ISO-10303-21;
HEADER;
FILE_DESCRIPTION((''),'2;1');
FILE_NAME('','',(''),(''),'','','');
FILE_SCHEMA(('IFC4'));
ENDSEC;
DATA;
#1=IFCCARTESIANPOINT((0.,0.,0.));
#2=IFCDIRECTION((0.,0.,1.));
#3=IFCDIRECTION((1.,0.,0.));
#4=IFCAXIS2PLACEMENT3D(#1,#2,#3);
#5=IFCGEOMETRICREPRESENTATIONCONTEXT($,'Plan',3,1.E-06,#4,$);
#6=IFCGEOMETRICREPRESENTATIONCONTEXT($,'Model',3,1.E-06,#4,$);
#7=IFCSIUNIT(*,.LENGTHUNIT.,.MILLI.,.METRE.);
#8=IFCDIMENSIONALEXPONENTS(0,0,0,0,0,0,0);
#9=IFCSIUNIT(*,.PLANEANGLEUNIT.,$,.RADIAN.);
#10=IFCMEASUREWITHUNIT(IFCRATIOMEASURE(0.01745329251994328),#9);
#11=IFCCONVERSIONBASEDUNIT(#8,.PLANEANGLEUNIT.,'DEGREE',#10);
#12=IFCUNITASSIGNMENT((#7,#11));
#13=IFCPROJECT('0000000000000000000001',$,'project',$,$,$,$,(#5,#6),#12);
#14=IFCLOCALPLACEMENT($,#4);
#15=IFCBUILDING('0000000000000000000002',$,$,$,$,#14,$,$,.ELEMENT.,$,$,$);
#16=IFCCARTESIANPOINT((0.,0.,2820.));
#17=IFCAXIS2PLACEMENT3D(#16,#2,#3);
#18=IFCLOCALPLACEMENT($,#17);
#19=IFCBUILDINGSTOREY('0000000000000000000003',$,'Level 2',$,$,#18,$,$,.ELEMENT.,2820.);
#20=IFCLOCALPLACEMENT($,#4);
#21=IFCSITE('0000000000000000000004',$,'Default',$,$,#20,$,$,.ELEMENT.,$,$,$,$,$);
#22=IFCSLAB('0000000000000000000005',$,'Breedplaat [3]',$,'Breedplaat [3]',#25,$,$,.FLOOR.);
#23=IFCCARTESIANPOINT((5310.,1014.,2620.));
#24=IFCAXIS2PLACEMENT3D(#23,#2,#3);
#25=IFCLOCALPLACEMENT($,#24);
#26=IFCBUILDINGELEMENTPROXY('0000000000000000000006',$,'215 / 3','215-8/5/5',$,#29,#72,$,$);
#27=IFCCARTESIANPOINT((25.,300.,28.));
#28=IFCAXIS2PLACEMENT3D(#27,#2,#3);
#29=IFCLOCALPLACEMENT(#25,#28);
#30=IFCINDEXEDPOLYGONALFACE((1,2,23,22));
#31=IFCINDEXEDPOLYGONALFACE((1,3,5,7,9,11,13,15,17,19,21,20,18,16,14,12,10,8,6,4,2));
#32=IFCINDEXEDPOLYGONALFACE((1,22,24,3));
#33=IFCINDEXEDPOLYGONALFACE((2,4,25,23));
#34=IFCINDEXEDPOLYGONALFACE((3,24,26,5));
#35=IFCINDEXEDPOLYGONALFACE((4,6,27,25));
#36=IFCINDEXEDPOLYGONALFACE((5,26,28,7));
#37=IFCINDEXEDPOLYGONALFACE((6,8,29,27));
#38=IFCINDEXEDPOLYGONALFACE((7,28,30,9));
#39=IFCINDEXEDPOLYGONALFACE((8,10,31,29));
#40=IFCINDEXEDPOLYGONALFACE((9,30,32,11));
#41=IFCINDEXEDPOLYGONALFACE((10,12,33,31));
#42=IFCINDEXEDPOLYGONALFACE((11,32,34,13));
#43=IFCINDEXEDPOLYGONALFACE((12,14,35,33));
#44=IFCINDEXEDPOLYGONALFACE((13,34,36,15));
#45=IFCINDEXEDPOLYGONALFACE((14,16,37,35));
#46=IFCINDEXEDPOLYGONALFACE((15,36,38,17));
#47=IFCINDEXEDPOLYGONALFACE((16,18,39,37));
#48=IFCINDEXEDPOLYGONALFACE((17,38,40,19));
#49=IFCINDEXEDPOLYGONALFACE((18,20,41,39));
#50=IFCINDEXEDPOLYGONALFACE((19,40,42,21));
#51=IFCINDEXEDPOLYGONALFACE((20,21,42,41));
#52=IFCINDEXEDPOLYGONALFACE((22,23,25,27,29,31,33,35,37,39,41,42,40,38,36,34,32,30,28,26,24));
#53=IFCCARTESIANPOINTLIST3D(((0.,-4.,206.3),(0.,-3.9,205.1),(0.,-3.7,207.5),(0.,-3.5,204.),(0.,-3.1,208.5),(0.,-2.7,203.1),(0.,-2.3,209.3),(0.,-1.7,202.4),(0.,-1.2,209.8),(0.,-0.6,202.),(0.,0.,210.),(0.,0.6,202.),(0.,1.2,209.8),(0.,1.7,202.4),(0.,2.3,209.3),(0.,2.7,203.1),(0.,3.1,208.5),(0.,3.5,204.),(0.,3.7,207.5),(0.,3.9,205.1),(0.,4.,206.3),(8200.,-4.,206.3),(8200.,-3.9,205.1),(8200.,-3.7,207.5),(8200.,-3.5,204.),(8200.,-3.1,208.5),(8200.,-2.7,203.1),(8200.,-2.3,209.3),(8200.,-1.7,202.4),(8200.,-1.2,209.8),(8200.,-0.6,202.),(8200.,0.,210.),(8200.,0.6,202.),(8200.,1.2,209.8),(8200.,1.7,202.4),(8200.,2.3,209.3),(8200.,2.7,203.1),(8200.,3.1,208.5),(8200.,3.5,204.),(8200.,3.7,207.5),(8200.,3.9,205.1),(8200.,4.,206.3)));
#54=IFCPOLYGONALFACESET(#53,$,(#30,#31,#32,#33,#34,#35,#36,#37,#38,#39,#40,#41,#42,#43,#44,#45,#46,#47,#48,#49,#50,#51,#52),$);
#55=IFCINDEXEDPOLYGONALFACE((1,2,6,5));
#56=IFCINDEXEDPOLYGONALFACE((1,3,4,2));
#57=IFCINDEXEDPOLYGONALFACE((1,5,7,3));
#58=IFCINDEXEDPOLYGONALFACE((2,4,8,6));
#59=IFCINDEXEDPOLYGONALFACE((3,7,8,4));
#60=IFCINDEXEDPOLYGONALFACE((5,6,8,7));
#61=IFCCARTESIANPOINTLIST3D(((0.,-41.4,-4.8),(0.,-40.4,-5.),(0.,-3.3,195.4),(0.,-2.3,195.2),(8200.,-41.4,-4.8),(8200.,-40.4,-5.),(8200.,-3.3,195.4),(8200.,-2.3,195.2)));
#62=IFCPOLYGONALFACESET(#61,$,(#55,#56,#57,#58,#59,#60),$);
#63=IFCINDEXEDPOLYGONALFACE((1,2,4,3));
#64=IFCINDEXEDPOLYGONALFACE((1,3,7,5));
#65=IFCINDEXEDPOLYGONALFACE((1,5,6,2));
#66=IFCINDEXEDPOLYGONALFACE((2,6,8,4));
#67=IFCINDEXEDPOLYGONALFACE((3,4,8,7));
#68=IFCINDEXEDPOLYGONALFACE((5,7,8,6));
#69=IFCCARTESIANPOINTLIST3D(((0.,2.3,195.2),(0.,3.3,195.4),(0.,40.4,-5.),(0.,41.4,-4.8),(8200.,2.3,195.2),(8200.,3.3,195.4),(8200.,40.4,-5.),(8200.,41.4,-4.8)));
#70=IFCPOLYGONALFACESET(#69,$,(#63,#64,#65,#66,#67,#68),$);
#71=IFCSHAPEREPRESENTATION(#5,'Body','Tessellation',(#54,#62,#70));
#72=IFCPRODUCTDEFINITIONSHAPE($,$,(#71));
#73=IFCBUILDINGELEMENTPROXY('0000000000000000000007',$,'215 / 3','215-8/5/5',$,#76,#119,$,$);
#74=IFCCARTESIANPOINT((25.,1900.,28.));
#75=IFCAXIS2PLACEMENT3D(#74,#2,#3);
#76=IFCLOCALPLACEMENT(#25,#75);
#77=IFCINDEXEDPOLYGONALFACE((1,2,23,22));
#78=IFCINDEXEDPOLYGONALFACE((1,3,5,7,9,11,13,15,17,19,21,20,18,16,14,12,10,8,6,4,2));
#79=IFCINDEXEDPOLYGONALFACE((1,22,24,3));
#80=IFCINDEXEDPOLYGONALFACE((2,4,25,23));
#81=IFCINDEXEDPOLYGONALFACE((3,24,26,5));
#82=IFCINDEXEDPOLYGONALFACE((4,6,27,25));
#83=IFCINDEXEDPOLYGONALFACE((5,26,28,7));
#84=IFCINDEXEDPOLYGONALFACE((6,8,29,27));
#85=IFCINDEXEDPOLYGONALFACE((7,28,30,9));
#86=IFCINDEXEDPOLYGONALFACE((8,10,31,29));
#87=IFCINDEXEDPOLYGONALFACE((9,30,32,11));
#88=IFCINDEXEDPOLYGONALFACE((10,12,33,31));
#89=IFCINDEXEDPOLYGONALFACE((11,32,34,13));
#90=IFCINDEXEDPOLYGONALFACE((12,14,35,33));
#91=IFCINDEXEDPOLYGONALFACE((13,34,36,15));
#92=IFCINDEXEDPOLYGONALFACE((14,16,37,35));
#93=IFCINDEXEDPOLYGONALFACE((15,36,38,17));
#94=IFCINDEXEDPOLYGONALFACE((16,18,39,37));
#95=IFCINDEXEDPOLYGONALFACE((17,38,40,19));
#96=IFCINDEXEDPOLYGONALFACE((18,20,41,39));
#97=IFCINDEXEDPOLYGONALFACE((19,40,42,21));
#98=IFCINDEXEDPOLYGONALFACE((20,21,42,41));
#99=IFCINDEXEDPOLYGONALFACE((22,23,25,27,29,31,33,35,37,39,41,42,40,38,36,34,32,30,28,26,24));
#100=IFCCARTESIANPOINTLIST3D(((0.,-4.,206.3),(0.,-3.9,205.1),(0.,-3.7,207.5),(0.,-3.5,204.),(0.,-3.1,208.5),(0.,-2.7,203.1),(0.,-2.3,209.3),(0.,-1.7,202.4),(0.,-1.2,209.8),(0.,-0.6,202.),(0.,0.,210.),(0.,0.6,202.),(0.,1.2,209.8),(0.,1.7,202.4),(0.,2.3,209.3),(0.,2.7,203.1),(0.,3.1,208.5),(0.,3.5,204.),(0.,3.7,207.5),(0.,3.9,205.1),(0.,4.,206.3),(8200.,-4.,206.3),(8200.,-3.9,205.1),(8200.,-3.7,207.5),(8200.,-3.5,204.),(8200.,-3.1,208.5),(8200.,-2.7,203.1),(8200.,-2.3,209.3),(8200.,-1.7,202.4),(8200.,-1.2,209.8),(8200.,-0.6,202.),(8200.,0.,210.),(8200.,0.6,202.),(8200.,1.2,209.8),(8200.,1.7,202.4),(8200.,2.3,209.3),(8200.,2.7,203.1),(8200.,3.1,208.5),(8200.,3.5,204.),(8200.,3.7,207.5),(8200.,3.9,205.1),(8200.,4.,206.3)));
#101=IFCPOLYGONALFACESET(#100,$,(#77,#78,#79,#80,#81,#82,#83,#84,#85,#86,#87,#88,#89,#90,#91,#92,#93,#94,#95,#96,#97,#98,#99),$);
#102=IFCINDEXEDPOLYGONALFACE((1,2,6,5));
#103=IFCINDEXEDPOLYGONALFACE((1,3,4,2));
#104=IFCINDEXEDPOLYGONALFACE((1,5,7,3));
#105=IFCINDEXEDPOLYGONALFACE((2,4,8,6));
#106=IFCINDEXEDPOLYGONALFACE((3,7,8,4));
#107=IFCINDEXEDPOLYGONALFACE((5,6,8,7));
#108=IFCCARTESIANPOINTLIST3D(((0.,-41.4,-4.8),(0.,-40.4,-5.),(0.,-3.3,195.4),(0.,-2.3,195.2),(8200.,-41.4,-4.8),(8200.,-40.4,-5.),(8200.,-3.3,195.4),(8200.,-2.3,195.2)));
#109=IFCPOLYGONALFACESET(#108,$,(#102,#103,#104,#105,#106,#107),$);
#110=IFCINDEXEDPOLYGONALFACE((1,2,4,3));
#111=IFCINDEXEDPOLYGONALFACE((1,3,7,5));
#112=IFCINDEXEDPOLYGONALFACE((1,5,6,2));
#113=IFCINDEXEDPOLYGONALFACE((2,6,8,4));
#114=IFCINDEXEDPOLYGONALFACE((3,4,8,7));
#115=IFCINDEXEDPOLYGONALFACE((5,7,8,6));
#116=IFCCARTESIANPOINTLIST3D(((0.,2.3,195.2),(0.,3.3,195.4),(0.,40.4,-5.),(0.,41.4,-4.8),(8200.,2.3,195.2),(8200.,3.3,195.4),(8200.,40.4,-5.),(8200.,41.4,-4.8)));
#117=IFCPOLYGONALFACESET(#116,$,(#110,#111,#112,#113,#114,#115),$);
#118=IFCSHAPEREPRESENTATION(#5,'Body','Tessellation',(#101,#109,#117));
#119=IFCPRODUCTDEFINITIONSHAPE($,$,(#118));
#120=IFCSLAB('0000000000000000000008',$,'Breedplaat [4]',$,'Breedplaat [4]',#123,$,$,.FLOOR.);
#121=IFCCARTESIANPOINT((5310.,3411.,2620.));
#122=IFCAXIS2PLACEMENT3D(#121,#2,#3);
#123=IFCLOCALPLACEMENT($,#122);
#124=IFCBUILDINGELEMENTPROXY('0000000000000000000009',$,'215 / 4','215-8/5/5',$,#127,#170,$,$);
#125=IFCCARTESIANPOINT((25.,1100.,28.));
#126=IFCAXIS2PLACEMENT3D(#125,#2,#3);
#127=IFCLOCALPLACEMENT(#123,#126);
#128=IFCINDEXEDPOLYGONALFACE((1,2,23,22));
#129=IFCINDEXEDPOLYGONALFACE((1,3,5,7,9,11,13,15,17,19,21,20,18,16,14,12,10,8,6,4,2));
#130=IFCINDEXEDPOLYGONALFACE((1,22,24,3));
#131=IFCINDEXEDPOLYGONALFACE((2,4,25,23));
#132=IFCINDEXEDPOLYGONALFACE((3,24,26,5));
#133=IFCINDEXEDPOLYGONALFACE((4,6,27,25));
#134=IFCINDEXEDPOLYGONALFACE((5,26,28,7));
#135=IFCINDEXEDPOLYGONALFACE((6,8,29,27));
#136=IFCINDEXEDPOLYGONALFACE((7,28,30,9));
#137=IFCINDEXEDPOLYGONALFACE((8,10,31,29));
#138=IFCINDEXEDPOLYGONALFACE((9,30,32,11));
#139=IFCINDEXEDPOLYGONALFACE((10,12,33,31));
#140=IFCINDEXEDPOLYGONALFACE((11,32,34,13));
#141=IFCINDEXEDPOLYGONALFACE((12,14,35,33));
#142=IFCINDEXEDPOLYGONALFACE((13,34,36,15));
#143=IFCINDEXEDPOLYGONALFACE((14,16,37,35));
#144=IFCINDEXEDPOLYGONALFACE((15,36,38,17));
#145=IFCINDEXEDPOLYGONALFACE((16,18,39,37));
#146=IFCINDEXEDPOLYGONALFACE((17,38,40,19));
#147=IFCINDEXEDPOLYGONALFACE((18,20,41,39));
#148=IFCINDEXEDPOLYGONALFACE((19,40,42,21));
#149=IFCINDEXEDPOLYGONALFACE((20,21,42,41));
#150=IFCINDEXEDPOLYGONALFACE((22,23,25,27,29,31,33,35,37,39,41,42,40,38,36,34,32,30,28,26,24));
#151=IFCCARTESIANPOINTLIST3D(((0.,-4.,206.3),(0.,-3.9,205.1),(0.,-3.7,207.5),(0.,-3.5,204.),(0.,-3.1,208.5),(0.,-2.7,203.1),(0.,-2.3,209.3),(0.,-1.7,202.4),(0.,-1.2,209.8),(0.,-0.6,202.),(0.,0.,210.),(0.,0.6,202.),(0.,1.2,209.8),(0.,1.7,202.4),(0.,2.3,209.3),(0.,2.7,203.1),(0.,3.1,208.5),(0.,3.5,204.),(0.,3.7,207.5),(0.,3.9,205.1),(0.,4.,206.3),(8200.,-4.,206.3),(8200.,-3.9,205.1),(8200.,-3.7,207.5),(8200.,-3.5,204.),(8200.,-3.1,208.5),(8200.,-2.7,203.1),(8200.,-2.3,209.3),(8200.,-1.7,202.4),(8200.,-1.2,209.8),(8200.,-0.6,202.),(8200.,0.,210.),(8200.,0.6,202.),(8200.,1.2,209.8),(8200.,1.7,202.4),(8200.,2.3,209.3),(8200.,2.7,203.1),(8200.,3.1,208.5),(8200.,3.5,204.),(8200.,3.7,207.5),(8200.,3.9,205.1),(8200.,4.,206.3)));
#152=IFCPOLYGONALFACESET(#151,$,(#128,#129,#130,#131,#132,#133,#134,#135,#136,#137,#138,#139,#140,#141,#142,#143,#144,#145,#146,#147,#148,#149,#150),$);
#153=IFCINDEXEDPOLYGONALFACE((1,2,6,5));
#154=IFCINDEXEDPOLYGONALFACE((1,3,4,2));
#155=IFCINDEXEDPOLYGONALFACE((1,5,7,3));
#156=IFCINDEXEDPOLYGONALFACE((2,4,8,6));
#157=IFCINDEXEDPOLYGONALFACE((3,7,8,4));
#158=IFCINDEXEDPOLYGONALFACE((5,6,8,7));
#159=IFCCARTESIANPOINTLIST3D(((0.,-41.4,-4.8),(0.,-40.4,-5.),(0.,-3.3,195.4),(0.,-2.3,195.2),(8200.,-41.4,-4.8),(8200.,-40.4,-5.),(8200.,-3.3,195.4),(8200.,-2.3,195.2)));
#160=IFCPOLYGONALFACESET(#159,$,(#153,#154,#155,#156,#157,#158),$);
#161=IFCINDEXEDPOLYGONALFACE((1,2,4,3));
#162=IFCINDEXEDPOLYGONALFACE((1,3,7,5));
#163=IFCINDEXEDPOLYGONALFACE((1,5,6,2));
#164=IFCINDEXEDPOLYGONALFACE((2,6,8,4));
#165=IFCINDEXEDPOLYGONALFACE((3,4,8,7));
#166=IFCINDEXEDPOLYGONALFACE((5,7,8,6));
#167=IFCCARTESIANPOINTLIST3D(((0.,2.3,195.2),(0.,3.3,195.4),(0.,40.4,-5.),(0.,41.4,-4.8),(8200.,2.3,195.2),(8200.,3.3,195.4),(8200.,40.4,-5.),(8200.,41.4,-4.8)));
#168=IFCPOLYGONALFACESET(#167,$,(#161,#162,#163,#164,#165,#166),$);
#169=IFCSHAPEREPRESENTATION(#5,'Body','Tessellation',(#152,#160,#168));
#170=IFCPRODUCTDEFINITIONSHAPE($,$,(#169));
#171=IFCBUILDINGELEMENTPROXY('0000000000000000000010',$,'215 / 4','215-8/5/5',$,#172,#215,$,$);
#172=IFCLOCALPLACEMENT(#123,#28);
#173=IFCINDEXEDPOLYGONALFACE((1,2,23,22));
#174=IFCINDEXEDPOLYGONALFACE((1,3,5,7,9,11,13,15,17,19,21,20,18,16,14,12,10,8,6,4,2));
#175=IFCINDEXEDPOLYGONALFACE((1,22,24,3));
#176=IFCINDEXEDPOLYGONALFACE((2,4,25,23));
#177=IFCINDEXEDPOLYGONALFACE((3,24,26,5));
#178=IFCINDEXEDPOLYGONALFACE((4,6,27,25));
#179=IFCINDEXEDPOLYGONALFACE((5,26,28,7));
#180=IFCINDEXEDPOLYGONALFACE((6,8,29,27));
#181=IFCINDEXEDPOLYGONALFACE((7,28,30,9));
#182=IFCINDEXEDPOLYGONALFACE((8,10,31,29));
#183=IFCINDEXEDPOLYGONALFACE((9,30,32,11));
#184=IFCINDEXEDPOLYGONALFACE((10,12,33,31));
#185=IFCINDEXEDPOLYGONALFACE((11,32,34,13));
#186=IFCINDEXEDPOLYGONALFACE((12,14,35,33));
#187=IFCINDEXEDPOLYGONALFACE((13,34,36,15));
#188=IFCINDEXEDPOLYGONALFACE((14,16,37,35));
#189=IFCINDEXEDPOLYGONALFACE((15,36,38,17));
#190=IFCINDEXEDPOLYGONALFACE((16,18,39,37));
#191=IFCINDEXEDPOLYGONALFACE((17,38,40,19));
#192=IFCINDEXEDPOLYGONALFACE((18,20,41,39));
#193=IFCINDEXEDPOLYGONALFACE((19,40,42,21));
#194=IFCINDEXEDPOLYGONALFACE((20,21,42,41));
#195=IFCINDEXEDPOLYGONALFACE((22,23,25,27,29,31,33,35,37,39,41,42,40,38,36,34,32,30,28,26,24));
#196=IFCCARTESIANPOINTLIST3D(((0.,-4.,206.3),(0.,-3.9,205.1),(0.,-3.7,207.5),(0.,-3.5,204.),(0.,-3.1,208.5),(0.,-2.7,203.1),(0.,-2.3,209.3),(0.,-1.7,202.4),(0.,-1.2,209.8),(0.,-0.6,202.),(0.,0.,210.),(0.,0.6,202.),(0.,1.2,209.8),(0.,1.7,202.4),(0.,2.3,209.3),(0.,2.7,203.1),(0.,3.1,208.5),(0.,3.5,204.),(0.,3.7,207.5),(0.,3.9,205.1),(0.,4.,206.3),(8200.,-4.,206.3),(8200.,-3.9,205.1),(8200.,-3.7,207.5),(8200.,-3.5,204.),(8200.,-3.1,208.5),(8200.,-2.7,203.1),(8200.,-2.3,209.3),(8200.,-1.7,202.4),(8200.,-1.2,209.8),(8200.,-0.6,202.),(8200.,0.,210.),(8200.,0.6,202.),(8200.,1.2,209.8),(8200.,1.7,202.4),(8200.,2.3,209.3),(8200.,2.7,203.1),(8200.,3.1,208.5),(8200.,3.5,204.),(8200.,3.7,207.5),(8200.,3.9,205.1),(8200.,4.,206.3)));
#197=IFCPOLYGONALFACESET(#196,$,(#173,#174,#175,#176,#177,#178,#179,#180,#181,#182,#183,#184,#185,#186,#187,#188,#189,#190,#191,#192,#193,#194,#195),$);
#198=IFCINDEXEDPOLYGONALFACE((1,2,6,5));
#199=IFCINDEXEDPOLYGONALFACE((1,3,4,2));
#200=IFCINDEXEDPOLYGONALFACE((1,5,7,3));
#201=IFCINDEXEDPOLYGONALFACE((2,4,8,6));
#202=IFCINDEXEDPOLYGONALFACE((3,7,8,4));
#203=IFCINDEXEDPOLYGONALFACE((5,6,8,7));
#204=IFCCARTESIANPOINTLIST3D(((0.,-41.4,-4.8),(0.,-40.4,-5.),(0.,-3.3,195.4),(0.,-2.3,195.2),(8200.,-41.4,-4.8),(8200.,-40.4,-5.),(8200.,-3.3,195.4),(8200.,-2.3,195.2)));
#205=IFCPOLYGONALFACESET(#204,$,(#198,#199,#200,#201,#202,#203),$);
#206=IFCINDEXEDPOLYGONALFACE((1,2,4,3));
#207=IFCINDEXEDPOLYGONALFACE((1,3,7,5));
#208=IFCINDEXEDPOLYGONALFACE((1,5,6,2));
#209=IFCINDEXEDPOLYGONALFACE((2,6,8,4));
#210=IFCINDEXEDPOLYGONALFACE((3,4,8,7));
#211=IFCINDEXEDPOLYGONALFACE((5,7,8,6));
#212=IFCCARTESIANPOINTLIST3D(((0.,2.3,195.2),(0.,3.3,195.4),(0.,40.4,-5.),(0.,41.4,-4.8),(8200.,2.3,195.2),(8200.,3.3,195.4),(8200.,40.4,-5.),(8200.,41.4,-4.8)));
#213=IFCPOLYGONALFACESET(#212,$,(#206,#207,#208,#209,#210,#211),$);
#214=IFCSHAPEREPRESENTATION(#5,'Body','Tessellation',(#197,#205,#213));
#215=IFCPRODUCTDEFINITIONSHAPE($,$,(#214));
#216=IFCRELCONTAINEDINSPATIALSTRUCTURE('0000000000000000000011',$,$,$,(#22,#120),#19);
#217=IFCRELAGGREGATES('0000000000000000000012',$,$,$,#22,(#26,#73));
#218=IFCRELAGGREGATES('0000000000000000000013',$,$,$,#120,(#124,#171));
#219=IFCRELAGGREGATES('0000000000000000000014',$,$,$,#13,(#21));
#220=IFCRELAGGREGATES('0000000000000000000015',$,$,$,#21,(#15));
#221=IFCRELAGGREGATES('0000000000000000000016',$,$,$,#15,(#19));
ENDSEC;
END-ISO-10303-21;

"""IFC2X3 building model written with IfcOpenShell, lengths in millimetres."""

from ifc_helpers import new_model, entity, si_unit, converted_unit, frame, origin_with_axes, origin_2d_with_axis, place, context, project, spatial, rectangle, circle, extrude, element, aggregate, save


model = new_model("IFC2X3")

# Units and contexts
plan_context = context("Plan", 3, precision=1e-06, world=origin_with_axes())
model_context = context("Model", 3, precision=1e-06, world=origin_with_axes())
ifc_project = project(units=[si_unit("LENGTHUNIT", "METRE", prefix="MILLI"), converted_unit("PLANEANGLEUNIT", "DEGREE", entity("IfcRatioMeasure", 0.01745329251994328), si_unit("PLANEANGLEUNIT", "RADIAN"), dimensions=[0, 0, 0, 0, 0, 0, 0])], contexts=[plan_context, model_context])

# Site, building, storey
site_placement = place(None, origin_with_axes())
site = spatial("IfcSite", under=ifc_project, at=site_placement, Name="Default", CompositionType="ELEMENT")
building_placement = place(None, origin_with_axes())
building = spatial("IfcBuilding", under=site, at=building_placement, CompositionType="ELEMENT")
storey_placement = place(None, frame((0.0, 0.0, 2820.0), z_axis=(0.0, 0.0, 1.0), x_axis=(1.0, 0.0, 0.0)))
storey = spatial("IfcBuildingStorey", under=building, at=storey_placement, Name="Level 2", CompositionType="ELEMENT", Elevation=2820.0)

# Slabs, building element proxies
slab_1_placement = place(None, frame((5310.0, 1014.0, 2620.0), z_axis=(0.0, 0.0, 1.0), x_axis=(1.0, 0.0, 0.0)))
slab_1 = element("IfcSlab", 1, at=slab_1_placement, inside=storey, Name="Breedplaat [3]", ObjectType="Breedplaat [3]", PredefinedType="FLOOR")
proxy_1_placement = place(slab_1_placement, frame((25.0, 300.0, 28.0), z_axis=(0.0, 0.0, 1.0), x_axis=(1.0, 0.0, 0.0)))
proxy_1 = element("IfcBuildingElementProxy", 2, at=proxy_1_placement, Name="215 / 3", Description="215-8/5/5", context=plan_context, shape_type="SweptSolid", body=[
    extrude(circle(Radius=4.0, at=origin_2d_with_axis()), frame((0.0, 0.0, 206.0), z_axis=(1.0, 0.0, 0.0), x_axis=(0.0, 0.0, 1.0)), (0.0, 0.0, 1.0), 8200.0),
    extrude(rectangle(XDim=203.8, YDim=1.0, at=origin_2d_with_axis()), frame((0.0, -21.9, 95.2), z_axis=(1.0, 0.0, 0.0), x_axis=(0.0, 0.187112, 0.982339)), (0.0, 0.0, 1.0), 8200.0),
    extrude(rectangle(XDim=203.8, YDim=1.0, at=origin_2d_with_axis()), frame((0.0, 21.9, 95.2), z_axis=(1.0, 0.0, 0.0), x_axis=(0.0, -0.187112, 0.982339)), (0.0, 0.0, 1.0), 8200.0),
])
proxy_2_placement = place(slab_1_placement, frame((25.0, 1900.0, 28.0), z_axis=(0.0, 0.0, 1.0), x_axis=(1.0, 0.0, 0.0)))
proxy_2 = element("IfcBuildingElementProxy", 3, at=proxy_2_placement, Name="215 / 3", Description="215-8/5/5", context=plan_context, shape_type="SweptSolid", body=[
    extrude(circle(Radius=4.0, at=origin_2d_with_axis()), frame((0.0, 0.0, 206.0), z_axis=(1.0, 0.0, 0.0), x_axis=(0.0, 0.0, 1.0)), (0.0, 0.0, 1.0), 8200.0),
    extrude(rectangle(XDim=203.8, YDim=1.0, at=origin_2d_with_axis()), frame((0.0, -21.9, 95.2), z_axis=(1.0, 0.0, 0.0), x_axis=(0.0, 0.187112, 0.982339)), (0.0, 0.0, 1.0), 8200.0),
    extrude(rectangle(XDim=203.8, YDim=1.0, at=origin_2d_with_axis()), frame((0.0, 21.9, 95.2), z_axis=(1.0, 0.0, 0.0), x_axis=(0.0, -0.187112, 0.982339)), (0.0, 0.0, 1.0), 8200.0),
])
aggregate(slab_1, [proxy_1, proxy_2])
slab_2_placement = place(None, frame((5310.0, 3411.0, 2620.0), z_axis=(0.0, 0.0, 1.0), x_axis=(1.0, 0.0, 0.0)))
slab_2 = element("IfcSlab", 4, at=slab_2_placement, inside=storey, Name="Breedplaat [4]", ObjectType="Breedplaat [4]", PredefinedType="FLOOR")
proxy_3_placement = place(slab_2_placement, frame((25.0, 1100.0, 28.0), z_axis=(0.0, 0.0, 1.0), x_axis=(1.0, 0.0, 0.0)))
proxy_3 = element("IfcBuildingElementProxy", 5, at=proxy_3_placement, Name="215 / 4", Description="215-8/5/5", context=plan_context, shape_type="SweptSolid", body=[
    extrude(circle(Radius=4.0, at=origin_2d_with_axis()), frame((0.0, 0.0, 206.0), z_axis=(1.0, 0.0, 0.0), x_axis=(0.0, 0.0, 1.0)), (0.0, 0.0, 1.0), 8200.0),
    extrude(rectangle(XDim=203.8, YDim=1.0, at=origin_2d_with_axis()), frame((0.0, -21.9, 95.2), z_axis=(1.0, 0.0, 0.0), x_axis=(0.0, 0.187112, 0.982339)), (0.0, 0.0, 1.0), 8200.0),
    extrude(rectangle(XDim=203.8, YDim=1.0, at=origin_2d_with_axis()), frame((0.0, 21.9, 95.2), z_axis=(1.0, 0.0, 0.0), x_axis=(0.0, -0.187112, 0.982339)), (0.0, 0.0, 1.0), 8200.0),
])
proxy_4_placement = place(slab_2_placement, frame((25.0, 300.0, 28.0), z_axis=(0.0, 0.0, 1.0), x_axis=(1.0, 0.0, 0.0)))
proxy_4 = element("IfcBuildingElementProxy", 6, at=proxy_4_placement, Name="215 / 4", Description="215-8/5/5", context=plan_context, shape_type="SweptSolid", body=[
    extrude(circle(Radius=4.0, at=origin_2d_with_axis()), frame((0.0, 0.0, 206.0), z_axis=(1.0, 0.0, 0.0), x_axis=(0.0, 0.0, 1.0)), (0.0, 0.0, 1.0), 8200.0),
    extrude(rectangle(XDim=203.8, YDim=1.0, at=origin_2d_with_axis()), frame((0.0, -21.9, 95.2), z_axis=(1.0, 0.0, 0.0), x_axis=(0.0, 0.187112, 0.982339)), (0.0, 0.0, 1.0), 8200.0),
    extrude(rectangle(XDim=203.8, YDim=1.0, at=origin_2d_with_axis()), frame((0.0, 21.9, 95.2), z_axis=(1.0, 0.0, 0.0), x_axis=(0.0, -0.187112, 0.982339)), (0.0, 0.0, 1.0), 8200.0),
])
aggregate(slab_2, [proxy_3, proxy_4])

save(model, "model.ifc")
